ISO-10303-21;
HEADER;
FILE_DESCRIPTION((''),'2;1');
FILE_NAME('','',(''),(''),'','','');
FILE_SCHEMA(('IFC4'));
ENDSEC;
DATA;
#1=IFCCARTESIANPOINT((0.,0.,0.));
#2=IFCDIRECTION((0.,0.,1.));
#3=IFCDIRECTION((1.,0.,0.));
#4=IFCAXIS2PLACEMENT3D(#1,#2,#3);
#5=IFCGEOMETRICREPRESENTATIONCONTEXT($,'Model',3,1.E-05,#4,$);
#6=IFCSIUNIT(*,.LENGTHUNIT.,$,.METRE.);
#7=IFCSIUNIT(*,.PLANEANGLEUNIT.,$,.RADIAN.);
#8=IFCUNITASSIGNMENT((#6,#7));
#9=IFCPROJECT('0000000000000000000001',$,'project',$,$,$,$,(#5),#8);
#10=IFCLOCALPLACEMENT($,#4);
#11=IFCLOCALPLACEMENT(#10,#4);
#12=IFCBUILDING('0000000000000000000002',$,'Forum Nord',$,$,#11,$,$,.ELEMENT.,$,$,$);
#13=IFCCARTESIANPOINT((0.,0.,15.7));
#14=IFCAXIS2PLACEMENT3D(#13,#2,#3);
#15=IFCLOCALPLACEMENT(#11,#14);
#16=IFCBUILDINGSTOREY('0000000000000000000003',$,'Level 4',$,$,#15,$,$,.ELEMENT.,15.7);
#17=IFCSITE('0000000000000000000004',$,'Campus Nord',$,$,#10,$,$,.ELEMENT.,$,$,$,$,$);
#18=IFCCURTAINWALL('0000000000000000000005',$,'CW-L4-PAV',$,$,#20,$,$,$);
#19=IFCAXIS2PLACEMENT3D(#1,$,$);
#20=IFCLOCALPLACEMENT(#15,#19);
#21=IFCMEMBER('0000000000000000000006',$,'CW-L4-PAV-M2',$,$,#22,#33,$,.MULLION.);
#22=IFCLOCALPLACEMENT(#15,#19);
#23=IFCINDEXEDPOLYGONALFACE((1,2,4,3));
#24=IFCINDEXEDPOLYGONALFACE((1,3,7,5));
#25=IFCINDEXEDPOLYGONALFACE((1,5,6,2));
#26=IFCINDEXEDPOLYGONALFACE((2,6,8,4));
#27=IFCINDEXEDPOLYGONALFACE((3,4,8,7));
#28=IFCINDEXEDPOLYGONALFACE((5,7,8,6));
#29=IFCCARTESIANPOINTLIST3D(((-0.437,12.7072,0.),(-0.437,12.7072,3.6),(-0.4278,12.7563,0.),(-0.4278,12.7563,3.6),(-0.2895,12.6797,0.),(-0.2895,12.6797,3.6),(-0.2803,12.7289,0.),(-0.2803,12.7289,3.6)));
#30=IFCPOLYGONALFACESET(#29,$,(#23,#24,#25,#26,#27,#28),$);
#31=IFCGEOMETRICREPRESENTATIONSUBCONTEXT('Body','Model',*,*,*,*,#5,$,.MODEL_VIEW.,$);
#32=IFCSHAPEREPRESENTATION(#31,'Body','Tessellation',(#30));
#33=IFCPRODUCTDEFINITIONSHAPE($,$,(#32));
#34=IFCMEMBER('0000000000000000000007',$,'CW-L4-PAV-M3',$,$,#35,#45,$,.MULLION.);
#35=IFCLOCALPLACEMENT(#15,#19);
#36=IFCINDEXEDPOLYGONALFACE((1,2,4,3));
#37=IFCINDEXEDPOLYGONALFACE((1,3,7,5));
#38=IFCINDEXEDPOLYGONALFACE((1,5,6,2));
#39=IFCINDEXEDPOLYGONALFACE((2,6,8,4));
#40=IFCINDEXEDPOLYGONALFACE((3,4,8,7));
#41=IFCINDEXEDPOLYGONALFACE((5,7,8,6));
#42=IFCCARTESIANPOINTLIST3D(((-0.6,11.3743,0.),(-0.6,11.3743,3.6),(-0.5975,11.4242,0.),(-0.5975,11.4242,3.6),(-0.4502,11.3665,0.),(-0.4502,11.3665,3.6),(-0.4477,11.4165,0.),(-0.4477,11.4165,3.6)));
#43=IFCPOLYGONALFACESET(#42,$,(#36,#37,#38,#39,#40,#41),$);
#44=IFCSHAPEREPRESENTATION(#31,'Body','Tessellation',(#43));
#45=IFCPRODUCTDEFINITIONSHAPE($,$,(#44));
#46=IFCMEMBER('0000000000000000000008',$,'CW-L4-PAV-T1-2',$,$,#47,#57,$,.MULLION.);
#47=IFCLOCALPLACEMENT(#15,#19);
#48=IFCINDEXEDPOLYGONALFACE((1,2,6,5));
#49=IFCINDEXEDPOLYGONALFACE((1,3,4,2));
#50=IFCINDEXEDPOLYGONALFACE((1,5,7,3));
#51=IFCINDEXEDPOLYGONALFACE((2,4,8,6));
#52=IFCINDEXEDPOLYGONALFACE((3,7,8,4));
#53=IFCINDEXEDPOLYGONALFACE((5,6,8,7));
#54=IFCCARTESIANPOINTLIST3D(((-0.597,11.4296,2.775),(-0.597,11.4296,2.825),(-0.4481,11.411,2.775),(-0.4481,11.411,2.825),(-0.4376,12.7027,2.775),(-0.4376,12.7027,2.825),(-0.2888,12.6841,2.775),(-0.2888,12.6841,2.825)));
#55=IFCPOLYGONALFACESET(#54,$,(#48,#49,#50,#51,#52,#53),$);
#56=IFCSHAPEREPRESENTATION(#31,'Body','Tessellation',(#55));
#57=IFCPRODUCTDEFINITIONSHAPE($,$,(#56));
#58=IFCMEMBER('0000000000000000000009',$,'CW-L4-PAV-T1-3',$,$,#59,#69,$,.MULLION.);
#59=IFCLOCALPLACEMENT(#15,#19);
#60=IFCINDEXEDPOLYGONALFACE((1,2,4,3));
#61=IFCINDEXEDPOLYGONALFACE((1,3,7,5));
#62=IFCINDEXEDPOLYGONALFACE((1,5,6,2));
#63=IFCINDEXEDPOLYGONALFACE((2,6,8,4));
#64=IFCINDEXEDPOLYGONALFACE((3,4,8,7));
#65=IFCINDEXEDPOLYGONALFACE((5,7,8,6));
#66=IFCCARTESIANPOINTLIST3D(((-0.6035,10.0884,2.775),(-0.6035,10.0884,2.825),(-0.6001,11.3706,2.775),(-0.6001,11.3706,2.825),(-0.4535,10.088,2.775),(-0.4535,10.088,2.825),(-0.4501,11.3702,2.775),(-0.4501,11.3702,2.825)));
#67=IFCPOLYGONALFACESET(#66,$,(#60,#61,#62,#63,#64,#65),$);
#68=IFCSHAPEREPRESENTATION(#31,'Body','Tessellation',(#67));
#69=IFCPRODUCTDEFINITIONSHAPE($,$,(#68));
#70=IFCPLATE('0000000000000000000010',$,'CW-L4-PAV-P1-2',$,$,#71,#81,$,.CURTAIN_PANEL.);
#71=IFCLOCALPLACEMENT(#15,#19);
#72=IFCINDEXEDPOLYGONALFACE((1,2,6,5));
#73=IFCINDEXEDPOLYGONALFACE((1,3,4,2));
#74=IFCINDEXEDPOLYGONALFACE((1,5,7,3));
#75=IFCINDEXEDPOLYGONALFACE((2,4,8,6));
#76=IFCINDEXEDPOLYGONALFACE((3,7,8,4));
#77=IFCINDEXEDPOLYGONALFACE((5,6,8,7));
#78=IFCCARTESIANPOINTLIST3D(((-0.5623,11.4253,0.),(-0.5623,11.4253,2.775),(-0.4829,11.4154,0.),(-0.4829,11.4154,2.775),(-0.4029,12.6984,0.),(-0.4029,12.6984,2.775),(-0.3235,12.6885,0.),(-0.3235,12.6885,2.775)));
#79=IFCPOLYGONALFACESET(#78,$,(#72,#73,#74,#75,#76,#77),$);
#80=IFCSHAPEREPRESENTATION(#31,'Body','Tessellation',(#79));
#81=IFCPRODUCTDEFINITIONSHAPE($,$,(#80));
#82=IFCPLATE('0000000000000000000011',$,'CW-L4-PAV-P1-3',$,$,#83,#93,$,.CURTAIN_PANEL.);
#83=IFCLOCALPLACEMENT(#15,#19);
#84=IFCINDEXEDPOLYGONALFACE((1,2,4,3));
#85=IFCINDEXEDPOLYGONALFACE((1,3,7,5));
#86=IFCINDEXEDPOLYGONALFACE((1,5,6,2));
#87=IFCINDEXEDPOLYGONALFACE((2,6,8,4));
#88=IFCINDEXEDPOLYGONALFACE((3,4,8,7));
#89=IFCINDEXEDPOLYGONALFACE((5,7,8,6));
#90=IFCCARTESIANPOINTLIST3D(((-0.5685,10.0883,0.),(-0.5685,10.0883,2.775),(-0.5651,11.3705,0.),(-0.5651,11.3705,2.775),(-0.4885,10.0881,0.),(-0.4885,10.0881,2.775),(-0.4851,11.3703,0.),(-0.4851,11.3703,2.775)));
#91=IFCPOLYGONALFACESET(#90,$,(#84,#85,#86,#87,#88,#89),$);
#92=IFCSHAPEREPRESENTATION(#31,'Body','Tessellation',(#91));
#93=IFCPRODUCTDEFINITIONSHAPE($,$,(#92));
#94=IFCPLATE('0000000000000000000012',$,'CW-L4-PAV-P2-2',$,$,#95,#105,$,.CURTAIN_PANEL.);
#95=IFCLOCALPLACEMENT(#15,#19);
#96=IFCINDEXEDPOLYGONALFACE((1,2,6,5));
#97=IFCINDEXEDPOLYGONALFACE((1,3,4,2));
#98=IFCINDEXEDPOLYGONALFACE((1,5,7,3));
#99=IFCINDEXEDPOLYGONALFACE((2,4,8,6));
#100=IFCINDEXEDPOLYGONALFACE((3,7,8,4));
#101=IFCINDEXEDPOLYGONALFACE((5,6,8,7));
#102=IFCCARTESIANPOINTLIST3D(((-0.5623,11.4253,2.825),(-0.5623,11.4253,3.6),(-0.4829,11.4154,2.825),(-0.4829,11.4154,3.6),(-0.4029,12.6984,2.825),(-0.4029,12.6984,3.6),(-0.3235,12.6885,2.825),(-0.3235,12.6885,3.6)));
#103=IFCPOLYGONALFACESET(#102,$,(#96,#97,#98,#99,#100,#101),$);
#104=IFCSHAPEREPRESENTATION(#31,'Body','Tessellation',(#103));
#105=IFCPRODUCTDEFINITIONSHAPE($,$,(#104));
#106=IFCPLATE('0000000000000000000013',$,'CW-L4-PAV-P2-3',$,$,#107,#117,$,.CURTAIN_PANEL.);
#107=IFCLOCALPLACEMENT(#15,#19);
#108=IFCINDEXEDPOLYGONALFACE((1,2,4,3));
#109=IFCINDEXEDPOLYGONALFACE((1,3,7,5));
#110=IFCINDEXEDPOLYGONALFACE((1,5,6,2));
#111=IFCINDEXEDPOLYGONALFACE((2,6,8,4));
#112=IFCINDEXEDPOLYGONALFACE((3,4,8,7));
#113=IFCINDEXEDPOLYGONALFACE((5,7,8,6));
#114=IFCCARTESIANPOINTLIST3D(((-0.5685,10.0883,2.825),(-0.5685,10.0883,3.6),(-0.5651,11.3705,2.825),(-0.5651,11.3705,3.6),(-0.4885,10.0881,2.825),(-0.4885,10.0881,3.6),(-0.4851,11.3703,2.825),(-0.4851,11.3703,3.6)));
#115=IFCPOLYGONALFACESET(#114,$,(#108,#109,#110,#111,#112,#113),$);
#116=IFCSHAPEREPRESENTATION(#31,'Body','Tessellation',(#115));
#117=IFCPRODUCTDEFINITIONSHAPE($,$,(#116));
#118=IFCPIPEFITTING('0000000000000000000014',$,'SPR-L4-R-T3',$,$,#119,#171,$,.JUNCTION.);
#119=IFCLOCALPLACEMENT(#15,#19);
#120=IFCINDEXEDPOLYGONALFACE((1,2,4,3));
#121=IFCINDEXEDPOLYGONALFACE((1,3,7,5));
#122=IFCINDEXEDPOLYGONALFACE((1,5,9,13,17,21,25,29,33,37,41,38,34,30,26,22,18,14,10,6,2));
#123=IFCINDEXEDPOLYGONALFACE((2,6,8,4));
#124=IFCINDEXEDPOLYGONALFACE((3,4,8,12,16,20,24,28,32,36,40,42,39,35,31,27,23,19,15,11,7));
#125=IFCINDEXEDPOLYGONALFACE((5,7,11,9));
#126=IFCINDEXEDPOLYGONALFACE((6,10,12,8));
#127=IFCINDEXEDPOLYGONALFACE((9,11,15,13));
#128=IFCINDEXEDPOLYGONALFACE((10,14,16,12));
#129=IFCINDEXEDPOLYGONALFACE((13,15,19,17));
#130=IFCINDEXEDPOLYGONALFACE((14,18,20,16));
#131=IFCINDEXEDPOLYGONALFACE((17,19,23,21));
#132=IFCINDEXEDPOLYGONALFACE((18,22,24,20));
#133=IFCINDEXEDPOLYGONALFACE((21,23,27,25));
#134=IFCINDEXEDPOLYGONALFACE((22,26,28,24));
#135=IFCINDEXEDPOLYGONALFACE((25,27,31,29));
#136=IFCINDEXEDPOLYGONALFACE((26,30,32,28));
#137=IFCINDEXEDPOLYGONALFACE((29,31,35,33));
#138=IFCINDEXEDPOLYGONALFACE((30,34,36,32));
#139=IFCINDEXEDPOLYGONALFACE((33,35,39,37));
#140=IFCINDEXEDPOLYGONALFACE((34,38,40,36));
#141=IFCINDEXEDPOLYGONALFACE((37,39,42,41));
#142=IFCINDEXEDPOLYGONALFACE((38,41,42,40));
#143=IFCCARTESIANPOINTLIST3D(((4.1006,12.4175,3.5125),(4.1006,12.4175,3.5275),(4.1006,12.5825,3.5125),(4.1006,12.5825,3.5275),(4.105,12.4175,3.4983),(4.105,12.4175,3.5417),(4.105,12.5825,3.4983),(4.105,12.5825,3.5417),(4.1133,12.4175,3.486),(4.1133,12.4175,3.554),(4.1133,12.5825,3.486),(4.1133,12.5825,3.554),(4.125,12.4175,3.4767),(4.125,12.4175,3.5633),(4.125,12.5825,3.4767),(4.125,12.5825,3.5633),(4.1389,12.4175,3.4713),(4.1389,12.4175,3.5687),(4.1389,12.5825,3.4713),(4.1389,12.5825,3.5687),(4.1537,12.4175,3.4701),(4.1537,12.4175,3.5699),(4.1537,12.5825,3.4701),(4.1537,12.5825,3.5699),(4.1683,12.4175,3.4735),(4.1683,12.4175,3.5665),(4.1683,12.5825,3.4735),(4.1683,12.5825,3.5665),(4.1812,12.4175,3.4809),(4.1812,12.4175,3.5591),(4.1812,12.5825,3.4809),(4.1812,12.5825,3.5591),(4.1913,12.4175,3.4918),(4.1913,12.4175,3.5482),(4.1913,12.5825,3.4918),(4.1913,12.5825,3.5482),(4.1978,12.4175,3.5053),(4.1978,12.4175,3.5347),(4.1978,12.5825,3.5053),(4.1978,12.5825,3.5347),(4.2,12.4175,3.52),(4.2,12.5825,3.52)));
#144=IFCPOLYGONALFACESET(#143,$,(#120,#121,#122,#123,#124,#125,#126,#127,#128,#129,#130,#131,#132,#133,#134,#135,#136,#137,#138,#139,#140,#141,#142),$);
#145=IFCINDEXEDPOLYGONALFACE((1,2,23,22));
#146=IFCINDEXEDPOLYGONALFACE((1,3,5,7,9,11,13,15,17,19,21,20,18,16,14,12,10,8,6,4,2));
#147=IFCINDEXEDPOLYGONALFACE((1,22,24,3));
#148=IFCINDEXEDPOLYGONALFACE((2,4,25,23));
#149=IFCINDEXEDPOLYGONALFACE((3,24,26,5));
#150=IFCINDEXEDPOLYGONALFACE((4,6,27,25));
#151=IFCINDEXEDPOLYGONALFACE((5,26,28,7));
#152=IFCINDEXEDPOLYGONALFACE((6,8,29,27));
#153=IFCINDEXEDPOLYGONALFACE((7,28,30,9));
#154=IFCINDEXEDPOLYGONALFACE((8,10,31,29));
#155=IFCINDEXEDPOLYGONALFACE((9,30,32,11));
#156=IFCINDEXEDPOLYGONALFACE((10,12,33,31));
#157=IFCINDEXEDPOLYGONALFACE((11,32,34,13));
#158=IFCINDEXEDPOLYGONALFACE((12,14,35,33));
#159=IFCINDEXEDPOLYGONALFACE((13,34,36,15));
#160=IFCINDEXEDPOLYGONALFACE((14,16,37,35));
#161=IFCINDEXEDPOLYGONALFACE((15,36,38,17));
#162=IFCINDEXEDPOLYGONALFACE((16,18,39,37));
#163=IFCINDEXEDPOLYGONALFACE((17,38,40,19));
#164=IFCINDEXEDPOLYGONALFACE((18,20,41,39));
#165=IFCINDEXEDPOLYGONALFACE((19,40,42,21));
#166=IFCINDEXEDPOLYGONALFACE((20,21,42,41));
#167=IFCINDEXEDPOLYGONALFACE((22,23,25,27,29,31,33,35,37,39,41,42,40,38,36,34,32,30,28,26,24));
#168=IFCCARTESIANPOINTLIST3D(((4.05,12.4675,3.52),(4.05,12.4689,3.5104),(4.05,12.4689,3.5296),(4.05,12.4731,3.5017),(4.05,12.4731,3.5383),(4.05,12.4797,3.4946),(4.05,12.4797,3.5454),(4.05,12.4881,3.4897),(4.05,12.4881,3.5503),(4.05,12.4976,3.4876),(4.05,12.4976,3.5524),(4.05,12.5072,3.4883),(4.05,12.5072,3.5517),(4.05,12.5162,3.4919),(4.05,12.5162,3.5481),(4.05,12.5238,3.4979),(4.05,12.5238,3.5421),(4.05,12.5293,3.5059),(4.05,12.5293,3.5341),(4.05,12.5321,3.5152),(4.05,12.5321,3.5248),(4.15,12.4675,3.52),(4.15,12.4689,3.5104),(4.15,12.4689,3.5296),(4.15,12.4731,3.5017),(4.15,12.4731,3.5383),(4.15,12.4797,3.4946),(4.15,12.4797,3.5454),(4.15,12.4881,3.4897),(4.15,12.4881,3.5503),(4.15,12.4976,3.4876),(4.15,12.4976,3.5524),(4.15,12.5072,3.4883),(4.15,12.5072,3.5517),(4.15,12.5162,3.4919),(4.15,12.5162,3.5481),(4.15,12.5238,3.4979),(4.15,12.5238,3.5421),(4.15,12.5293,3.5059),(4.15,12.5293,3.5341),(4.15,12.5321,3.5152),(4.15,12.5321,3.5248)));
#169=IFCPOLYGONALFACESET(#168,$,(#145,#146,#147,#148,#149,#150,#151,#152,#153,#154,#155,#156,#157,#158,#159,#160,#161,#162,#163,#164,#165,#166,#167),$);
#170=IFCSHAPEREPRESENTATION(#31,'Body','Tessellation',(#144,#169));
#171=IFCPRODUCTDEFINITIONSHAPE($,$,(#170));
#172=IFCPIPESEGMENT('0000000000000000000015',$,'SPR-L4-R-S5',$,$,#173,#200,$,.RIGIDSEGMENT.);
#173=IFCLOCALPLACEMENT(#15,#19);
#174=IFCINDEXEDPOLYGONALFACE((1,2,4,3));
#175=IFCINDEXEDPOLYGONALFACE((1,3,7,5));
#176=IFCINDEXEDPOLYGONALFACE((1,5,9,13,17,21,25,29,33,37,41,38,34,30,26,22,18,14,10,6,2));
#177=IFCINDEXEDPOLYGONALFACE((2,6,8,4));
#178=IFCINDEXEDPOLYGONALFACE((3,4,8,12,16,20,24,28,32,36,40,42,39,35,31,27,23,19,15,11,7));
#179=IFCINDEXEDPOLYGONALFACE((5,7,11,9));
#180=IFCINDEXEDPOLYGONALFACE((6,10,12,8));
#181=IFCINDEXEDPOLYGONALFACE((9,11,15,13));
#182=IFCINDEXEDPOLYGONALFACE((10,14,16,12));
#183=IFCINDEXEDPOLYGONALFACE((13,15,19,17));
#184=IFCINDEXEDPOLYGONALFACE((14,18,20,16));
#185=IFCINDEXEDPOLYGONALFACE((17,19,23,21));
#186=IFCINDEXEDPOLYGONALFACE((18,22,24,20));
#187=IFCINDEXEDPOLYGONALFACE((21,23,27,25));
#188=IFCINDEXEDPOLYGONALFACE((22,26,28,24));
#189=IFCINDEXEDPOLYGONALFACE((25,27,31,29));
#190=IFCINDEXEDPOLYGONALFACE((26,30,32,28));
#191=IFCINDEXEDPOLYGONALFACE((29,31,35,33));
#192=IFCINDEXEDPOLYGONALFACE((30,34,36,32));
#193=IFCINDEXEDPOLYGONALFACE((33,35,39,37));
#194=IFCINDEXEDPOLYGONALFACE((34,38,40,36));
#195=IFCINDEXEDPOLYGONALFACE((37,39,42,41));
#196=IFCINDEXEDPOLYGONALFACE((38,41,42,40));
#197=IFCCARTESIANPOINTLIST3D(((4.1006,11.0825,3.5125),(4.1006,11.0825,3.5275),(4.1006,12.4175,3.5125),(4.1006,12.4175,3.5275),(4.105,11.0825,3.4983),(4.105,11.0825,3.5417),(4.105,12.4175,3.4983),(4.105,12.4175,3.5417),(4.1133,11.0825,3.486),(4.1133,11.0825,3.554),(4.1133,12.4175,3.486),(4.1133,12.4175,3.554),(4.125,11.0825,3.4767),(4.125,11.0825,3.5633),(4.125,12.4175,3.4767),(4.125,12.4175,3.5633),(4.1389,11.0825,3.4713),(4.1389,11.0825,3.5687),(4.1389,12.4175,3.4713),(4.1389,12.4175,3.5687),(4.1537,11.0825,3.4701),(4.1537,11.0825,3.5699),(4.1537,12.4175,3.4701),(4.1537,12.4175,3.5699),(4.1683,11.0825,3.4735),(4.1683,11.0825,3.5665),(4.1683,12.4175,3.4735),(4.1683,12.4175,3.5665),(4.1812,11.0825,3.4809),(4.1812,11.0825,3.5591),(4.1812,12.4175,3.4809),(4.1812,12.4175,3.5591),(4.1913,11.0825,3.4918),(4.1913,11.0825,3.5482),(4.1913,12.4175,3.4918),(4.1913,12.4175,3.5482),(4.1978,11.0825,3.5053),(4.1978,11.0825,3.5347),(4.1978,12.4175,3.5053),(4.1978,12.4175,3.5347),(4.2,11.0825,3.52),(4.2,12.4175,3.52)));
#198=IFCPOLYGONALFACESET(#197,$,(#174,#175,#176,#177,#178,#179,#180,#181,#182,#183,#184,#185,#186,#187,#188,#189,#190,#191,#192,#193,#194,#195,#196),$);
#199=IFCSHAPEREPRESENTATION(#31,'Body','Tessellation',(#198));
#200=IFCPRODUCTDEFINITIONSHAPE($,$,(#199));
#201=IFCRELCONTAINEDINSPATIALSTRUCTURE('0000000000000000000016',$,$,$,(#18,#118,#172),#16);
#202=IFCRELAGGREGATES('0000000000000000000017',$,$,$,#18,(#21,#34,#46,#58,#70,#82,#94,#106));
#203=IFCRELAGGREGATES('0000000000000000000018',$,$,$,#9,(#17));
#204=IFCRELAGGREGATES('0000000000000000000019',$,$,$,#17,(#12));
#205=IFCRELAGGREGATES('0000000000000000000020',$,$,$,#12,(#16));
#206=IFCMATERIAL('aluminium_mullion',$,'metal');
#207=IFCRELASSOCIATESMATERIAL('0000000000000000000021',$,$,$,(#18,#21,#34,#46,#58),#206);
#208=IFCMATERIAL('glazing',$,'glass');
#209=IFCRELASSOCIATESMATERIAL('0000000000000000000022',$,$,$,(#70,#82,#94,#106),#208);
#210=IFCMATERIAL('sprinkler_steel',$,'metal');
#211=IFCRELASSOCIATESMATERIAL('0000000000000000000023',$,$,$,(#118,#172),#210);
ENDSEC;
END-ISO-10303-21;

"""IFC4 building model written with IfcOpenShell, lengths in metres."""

from ifc_helpers import new_model, si_unit, frame, frame_2d, origin_with_axes, origin_2d_with_axis, place, context, subcontext, project, spatial, rectangle, circle, extrude, material, element, aggregate, save


model = new_model("IFC4")

# Units and contexts
model_context = context("Model", 3, precision=1e-05, world=origin_with_axes())
body_context = subcontext(model_context, "Body", "Model", "MODEL_VIEW")
ifc_project = project(units=[si_unit("LENGTHUNIT", "METRE"), si_unit("PLANEANGLEUNIT", "RADIAN")], contexts=[model_context])

# Site, building, storey
site_placement = place(None, origin_with_axes())
site = spatial("IfcSite", under=ifc_project, at=site_placement, Name="Campus Nord", CompositionType="ELEMENT")
building_placement = place(site_placement, origin_with_axes())
building = spatial("IfcBuilding", under=site, at=building_placement, Name="Forum Nord", CompositionType="ELEMENT")
storey_placement = place(building_placement, frame((0.0, 0.0, 15.7), z_axis=(0.0, 0.0, 1.0), x_axis=(1.0, 0.0, 0.0)))
storey = spatial("IfcBuildingStorey", under=building, at=storey_placement, Name="Level 4", CompositionType="ELEMENT", Elevation=15.7)

# Curtain wall, members, plates
ifc_material_1 = material(Name="aluminium_mullion", Category="metal")
curtain_wall_placement = place(storey_placement, origin_with_axes())
curtain_wall = element("IfcCurtainWall", 1, at=curtain_wall_placement, inside=storey, material=ifc_material_1, Name="CW-L4-PAV")
member_1_placement = place(storey_placement, frame((-0.3587, 12.718, 0.0), z_axis=(0.0, 0.0, 1.0), x_axis=(-0.18296, -0.98312, 0.0)))
member_1 = element("IfcMember", 2, at=member_1_placement, material=ifc_material_1, Name="CW-L4-PAV-M2", PredefinedType="MULLION", context=body_context, shape_type="SweptSolid", body=[
    extrude(rectangle(XDim=0.05, YDim=0.15, at=origin_2d_with_axis()), origin_with_axes(), (0.0, 0.0, 1.0), 3.6),
])
member_2_placement = place(storey_placement, frame((-0.5239, 11.3954, 0.0), z_axis=(0.0, 0.0, 1.0), x_axis=(-0.05151, -0.99867, 0.0)))
member_2 = element("IfcMember", 3, at=member_2_placement, material=ifc_material_1, Name="CW-L4-PAV-M3", PredefinedType="MULLION", context=body_context, shape_type="SweptSolid", body=[
    extrude(rectangle(XDim=0.05, YDim=0.15, at=origin_2d_with_axis()), origin_with_axes(), (0.0, 0.0, 1.0), 3.6),
])
member_3_placement = place(storey_placement, frame((-0.3632, 12.6934, 2.8), z_axis=(-0.12419, -0.99226, 0.0), x_axis=(0.99226, -0.12419, 0.0)))
member_3 = element("IfcMember", 4, at=member_3_placement, material=ifc_material_1, Name="CW-L4-PAV-T1-2", PredefinedType="MULLION", context=body_context, shape_type="SweptSolid", body=[
    extrude(rectangle(XDim=0.15, YDim=0.05, at=origin_2d_with_axis()), origin_with_axes(), (0.0, 0.0, 1.0), 1.283),
])
member_4_placement = place(storey_placement, frame((-0.5251, 11.3704, 2.8), z_axis=(-0.00259, -1.0, 0.0), x_axis=(1.0, -0.00259, 0.0)))
member_4 = element("IfcMember", 5, at=member_4_placement, material=ifc_material_1, Name="CW-L4-PAV-T1-3", PredefinedType="MULLION", context=body_context, shape_type="SweptSolid", body=[
    extrude(rectangle(XDim=0.15, YDim=0.05, at=origin_2d_with_axis()), origin_with_axes(), (0.0, 0.0, 1.0), 1.2822),
])
ifc_material_2 = material(Name="glazing", Category="glass")
plate_1_placement = place(storey_placement, frame((-0.3632, 12.6934, 0.0), z_axis=(0.0, 0.0, 1.0), x_axis=(-0.12419, -0.99226, 0.0)))
plate_1 = element("IfcPlate", 6, at=plate_1_placement, material=ifc_material_2, Name="CW-L4-PAV-P1-2", PredefinedType="CURTAIN_PANEL", context=body_context, shape_type="SweptSolid", body=[
    extrude(rectangle(XDim=1.283, YDim=0.08, at=frame_2d((0.6415, 0.0), x_axis=(1.0, 0.0))), origin_with_axes(), (0.0, 0.0, 1.0), 2.775),
])
plate_2_placement = place(storey_placement, frame((-0.5251, 11.3704, 0.0), z_axis=(0.0, 0.0, 1.0), x_axis=(-0.00259, -1.0, 0.0)))
plate_2 = element("IfcPlate", 7, at=plate_2_placement, material=ifc_material_2, Name="CW-L4-PAV-P1-3", PredefinedType="CURTAIN_PANEL", context=body_context, shape_type="SweptSolid", body=[
    extrude(rectangle(XDim=1.2822, YDim=0.08, at=frame_2d((0.6411, 0.0), x_axis=(1.0, 0.0))), origin_with_axes(), (0.0, 0.0, 1.0), 2.775),
])
plate_3_placement = place(storey_placement, frame((-0.3632, 12.6934, 2.825), z_axis=(0.0, 0.0, 1.0), x_axis=(-0.12419, -0.99226, 0.0)))
plate_3 = element("IfcPlate", 8, at=plate_3_placement, material=ifc_material_2, Name="CW-L4-PAV-P2-2", PredefinedType="CURTAIN_PANEL", context=body_context, shape_type="SweptSolid", body=[
    extrude(rectangle(XDim=1.283, YDim=0.08, at=frame_2d((0.6415, 0.0), x_axis=(1.0, 0.0))), origin_with_axes(), (0.0, 0.0, 1.0), 0.775),
])
plate_4_placement = place(storey_placement, frame((-0.5251, 11.3704, 2.825), z_axis=(0.0, 0.0, 1.0), x_axis=(-0.00259, -1.0, 0.0)))
plate_4 = element("IfcPlate", 9, at=plate_4_placement, material=ifc_material_2, Name="CW-L4-PAV-P2-3", PredefinedType="CURTAIN_PANEL", context=body_context, shape_type="SweptSolid", body=[
    extrude(rectangle(XDim=1.2822, YDim=0.08, at=frame_2d((0.6411, 0.0), x_axis=(1.0, 0.0))), origin_with_axes(), (0.0, 0.0, 1.0), 0.775),
])
aggregate(curtain_wall, [member_1, member_2, member_3, member_4, plate_1, plate_2, plate_3, plate_4])

# Pipe fitting
ifc_material_3 = material(Name="sprinkler_steel", Category="metal")
pipe_fitting_1_placement = place(storey_placement, frame((4.15, 12.5825, 3.52), z_axis=(0.0, -1.0, 0.0), x_axis=(1.0, 0.0, 0.0)))
element("IfcPipeFitting", 10, at=pipe_fitting_1_placement, inside=storey, material=ifc_material_3, Name="SPR-L4-R-T3", PredefinedType="JUNCTION", context=body_context, shape_type="SweptSolid", body=[
    extrude(circle(Radius=0.05, at=origin_2d_with_axis()), origin_with_axes(), (0.0, 0.0, 1.0), 0.165),
    extrude(circle(Radius=0.0325, at=origin_2d_with_axis()), frame((0.0, 0.0, 0.0825), z_axis=(-1.0, 0.0, 0.0), x_axis=(0.0, 0.0, 1.0)), (0.0, 0.0, 1.0), 0.1),
])

# Pipe segment
pipe_segment_1_placement = place(storey_placement, frame((4.15, 12.4175, 3.52), z_axis=(0.0, -1.0, 0.0), x_axis=(1.0, 0.0, 0.0)))
element("IfcPipeSegment", 11, at=pipe_segment_1_placement, inside=storey, material=ifc_material_3, Name="SPR-L4-R-S5", PredefinedType="RIGIDSEGMENT", context=body_context, shape_type="SweptSolid", body=[
    extrude(circle(Radius=0.05, at=origin_2d_with_axis()), origin_with_axes(), (0.0, 0.0, 1.0), 1.335),
])

save(model, "model.ifc")
